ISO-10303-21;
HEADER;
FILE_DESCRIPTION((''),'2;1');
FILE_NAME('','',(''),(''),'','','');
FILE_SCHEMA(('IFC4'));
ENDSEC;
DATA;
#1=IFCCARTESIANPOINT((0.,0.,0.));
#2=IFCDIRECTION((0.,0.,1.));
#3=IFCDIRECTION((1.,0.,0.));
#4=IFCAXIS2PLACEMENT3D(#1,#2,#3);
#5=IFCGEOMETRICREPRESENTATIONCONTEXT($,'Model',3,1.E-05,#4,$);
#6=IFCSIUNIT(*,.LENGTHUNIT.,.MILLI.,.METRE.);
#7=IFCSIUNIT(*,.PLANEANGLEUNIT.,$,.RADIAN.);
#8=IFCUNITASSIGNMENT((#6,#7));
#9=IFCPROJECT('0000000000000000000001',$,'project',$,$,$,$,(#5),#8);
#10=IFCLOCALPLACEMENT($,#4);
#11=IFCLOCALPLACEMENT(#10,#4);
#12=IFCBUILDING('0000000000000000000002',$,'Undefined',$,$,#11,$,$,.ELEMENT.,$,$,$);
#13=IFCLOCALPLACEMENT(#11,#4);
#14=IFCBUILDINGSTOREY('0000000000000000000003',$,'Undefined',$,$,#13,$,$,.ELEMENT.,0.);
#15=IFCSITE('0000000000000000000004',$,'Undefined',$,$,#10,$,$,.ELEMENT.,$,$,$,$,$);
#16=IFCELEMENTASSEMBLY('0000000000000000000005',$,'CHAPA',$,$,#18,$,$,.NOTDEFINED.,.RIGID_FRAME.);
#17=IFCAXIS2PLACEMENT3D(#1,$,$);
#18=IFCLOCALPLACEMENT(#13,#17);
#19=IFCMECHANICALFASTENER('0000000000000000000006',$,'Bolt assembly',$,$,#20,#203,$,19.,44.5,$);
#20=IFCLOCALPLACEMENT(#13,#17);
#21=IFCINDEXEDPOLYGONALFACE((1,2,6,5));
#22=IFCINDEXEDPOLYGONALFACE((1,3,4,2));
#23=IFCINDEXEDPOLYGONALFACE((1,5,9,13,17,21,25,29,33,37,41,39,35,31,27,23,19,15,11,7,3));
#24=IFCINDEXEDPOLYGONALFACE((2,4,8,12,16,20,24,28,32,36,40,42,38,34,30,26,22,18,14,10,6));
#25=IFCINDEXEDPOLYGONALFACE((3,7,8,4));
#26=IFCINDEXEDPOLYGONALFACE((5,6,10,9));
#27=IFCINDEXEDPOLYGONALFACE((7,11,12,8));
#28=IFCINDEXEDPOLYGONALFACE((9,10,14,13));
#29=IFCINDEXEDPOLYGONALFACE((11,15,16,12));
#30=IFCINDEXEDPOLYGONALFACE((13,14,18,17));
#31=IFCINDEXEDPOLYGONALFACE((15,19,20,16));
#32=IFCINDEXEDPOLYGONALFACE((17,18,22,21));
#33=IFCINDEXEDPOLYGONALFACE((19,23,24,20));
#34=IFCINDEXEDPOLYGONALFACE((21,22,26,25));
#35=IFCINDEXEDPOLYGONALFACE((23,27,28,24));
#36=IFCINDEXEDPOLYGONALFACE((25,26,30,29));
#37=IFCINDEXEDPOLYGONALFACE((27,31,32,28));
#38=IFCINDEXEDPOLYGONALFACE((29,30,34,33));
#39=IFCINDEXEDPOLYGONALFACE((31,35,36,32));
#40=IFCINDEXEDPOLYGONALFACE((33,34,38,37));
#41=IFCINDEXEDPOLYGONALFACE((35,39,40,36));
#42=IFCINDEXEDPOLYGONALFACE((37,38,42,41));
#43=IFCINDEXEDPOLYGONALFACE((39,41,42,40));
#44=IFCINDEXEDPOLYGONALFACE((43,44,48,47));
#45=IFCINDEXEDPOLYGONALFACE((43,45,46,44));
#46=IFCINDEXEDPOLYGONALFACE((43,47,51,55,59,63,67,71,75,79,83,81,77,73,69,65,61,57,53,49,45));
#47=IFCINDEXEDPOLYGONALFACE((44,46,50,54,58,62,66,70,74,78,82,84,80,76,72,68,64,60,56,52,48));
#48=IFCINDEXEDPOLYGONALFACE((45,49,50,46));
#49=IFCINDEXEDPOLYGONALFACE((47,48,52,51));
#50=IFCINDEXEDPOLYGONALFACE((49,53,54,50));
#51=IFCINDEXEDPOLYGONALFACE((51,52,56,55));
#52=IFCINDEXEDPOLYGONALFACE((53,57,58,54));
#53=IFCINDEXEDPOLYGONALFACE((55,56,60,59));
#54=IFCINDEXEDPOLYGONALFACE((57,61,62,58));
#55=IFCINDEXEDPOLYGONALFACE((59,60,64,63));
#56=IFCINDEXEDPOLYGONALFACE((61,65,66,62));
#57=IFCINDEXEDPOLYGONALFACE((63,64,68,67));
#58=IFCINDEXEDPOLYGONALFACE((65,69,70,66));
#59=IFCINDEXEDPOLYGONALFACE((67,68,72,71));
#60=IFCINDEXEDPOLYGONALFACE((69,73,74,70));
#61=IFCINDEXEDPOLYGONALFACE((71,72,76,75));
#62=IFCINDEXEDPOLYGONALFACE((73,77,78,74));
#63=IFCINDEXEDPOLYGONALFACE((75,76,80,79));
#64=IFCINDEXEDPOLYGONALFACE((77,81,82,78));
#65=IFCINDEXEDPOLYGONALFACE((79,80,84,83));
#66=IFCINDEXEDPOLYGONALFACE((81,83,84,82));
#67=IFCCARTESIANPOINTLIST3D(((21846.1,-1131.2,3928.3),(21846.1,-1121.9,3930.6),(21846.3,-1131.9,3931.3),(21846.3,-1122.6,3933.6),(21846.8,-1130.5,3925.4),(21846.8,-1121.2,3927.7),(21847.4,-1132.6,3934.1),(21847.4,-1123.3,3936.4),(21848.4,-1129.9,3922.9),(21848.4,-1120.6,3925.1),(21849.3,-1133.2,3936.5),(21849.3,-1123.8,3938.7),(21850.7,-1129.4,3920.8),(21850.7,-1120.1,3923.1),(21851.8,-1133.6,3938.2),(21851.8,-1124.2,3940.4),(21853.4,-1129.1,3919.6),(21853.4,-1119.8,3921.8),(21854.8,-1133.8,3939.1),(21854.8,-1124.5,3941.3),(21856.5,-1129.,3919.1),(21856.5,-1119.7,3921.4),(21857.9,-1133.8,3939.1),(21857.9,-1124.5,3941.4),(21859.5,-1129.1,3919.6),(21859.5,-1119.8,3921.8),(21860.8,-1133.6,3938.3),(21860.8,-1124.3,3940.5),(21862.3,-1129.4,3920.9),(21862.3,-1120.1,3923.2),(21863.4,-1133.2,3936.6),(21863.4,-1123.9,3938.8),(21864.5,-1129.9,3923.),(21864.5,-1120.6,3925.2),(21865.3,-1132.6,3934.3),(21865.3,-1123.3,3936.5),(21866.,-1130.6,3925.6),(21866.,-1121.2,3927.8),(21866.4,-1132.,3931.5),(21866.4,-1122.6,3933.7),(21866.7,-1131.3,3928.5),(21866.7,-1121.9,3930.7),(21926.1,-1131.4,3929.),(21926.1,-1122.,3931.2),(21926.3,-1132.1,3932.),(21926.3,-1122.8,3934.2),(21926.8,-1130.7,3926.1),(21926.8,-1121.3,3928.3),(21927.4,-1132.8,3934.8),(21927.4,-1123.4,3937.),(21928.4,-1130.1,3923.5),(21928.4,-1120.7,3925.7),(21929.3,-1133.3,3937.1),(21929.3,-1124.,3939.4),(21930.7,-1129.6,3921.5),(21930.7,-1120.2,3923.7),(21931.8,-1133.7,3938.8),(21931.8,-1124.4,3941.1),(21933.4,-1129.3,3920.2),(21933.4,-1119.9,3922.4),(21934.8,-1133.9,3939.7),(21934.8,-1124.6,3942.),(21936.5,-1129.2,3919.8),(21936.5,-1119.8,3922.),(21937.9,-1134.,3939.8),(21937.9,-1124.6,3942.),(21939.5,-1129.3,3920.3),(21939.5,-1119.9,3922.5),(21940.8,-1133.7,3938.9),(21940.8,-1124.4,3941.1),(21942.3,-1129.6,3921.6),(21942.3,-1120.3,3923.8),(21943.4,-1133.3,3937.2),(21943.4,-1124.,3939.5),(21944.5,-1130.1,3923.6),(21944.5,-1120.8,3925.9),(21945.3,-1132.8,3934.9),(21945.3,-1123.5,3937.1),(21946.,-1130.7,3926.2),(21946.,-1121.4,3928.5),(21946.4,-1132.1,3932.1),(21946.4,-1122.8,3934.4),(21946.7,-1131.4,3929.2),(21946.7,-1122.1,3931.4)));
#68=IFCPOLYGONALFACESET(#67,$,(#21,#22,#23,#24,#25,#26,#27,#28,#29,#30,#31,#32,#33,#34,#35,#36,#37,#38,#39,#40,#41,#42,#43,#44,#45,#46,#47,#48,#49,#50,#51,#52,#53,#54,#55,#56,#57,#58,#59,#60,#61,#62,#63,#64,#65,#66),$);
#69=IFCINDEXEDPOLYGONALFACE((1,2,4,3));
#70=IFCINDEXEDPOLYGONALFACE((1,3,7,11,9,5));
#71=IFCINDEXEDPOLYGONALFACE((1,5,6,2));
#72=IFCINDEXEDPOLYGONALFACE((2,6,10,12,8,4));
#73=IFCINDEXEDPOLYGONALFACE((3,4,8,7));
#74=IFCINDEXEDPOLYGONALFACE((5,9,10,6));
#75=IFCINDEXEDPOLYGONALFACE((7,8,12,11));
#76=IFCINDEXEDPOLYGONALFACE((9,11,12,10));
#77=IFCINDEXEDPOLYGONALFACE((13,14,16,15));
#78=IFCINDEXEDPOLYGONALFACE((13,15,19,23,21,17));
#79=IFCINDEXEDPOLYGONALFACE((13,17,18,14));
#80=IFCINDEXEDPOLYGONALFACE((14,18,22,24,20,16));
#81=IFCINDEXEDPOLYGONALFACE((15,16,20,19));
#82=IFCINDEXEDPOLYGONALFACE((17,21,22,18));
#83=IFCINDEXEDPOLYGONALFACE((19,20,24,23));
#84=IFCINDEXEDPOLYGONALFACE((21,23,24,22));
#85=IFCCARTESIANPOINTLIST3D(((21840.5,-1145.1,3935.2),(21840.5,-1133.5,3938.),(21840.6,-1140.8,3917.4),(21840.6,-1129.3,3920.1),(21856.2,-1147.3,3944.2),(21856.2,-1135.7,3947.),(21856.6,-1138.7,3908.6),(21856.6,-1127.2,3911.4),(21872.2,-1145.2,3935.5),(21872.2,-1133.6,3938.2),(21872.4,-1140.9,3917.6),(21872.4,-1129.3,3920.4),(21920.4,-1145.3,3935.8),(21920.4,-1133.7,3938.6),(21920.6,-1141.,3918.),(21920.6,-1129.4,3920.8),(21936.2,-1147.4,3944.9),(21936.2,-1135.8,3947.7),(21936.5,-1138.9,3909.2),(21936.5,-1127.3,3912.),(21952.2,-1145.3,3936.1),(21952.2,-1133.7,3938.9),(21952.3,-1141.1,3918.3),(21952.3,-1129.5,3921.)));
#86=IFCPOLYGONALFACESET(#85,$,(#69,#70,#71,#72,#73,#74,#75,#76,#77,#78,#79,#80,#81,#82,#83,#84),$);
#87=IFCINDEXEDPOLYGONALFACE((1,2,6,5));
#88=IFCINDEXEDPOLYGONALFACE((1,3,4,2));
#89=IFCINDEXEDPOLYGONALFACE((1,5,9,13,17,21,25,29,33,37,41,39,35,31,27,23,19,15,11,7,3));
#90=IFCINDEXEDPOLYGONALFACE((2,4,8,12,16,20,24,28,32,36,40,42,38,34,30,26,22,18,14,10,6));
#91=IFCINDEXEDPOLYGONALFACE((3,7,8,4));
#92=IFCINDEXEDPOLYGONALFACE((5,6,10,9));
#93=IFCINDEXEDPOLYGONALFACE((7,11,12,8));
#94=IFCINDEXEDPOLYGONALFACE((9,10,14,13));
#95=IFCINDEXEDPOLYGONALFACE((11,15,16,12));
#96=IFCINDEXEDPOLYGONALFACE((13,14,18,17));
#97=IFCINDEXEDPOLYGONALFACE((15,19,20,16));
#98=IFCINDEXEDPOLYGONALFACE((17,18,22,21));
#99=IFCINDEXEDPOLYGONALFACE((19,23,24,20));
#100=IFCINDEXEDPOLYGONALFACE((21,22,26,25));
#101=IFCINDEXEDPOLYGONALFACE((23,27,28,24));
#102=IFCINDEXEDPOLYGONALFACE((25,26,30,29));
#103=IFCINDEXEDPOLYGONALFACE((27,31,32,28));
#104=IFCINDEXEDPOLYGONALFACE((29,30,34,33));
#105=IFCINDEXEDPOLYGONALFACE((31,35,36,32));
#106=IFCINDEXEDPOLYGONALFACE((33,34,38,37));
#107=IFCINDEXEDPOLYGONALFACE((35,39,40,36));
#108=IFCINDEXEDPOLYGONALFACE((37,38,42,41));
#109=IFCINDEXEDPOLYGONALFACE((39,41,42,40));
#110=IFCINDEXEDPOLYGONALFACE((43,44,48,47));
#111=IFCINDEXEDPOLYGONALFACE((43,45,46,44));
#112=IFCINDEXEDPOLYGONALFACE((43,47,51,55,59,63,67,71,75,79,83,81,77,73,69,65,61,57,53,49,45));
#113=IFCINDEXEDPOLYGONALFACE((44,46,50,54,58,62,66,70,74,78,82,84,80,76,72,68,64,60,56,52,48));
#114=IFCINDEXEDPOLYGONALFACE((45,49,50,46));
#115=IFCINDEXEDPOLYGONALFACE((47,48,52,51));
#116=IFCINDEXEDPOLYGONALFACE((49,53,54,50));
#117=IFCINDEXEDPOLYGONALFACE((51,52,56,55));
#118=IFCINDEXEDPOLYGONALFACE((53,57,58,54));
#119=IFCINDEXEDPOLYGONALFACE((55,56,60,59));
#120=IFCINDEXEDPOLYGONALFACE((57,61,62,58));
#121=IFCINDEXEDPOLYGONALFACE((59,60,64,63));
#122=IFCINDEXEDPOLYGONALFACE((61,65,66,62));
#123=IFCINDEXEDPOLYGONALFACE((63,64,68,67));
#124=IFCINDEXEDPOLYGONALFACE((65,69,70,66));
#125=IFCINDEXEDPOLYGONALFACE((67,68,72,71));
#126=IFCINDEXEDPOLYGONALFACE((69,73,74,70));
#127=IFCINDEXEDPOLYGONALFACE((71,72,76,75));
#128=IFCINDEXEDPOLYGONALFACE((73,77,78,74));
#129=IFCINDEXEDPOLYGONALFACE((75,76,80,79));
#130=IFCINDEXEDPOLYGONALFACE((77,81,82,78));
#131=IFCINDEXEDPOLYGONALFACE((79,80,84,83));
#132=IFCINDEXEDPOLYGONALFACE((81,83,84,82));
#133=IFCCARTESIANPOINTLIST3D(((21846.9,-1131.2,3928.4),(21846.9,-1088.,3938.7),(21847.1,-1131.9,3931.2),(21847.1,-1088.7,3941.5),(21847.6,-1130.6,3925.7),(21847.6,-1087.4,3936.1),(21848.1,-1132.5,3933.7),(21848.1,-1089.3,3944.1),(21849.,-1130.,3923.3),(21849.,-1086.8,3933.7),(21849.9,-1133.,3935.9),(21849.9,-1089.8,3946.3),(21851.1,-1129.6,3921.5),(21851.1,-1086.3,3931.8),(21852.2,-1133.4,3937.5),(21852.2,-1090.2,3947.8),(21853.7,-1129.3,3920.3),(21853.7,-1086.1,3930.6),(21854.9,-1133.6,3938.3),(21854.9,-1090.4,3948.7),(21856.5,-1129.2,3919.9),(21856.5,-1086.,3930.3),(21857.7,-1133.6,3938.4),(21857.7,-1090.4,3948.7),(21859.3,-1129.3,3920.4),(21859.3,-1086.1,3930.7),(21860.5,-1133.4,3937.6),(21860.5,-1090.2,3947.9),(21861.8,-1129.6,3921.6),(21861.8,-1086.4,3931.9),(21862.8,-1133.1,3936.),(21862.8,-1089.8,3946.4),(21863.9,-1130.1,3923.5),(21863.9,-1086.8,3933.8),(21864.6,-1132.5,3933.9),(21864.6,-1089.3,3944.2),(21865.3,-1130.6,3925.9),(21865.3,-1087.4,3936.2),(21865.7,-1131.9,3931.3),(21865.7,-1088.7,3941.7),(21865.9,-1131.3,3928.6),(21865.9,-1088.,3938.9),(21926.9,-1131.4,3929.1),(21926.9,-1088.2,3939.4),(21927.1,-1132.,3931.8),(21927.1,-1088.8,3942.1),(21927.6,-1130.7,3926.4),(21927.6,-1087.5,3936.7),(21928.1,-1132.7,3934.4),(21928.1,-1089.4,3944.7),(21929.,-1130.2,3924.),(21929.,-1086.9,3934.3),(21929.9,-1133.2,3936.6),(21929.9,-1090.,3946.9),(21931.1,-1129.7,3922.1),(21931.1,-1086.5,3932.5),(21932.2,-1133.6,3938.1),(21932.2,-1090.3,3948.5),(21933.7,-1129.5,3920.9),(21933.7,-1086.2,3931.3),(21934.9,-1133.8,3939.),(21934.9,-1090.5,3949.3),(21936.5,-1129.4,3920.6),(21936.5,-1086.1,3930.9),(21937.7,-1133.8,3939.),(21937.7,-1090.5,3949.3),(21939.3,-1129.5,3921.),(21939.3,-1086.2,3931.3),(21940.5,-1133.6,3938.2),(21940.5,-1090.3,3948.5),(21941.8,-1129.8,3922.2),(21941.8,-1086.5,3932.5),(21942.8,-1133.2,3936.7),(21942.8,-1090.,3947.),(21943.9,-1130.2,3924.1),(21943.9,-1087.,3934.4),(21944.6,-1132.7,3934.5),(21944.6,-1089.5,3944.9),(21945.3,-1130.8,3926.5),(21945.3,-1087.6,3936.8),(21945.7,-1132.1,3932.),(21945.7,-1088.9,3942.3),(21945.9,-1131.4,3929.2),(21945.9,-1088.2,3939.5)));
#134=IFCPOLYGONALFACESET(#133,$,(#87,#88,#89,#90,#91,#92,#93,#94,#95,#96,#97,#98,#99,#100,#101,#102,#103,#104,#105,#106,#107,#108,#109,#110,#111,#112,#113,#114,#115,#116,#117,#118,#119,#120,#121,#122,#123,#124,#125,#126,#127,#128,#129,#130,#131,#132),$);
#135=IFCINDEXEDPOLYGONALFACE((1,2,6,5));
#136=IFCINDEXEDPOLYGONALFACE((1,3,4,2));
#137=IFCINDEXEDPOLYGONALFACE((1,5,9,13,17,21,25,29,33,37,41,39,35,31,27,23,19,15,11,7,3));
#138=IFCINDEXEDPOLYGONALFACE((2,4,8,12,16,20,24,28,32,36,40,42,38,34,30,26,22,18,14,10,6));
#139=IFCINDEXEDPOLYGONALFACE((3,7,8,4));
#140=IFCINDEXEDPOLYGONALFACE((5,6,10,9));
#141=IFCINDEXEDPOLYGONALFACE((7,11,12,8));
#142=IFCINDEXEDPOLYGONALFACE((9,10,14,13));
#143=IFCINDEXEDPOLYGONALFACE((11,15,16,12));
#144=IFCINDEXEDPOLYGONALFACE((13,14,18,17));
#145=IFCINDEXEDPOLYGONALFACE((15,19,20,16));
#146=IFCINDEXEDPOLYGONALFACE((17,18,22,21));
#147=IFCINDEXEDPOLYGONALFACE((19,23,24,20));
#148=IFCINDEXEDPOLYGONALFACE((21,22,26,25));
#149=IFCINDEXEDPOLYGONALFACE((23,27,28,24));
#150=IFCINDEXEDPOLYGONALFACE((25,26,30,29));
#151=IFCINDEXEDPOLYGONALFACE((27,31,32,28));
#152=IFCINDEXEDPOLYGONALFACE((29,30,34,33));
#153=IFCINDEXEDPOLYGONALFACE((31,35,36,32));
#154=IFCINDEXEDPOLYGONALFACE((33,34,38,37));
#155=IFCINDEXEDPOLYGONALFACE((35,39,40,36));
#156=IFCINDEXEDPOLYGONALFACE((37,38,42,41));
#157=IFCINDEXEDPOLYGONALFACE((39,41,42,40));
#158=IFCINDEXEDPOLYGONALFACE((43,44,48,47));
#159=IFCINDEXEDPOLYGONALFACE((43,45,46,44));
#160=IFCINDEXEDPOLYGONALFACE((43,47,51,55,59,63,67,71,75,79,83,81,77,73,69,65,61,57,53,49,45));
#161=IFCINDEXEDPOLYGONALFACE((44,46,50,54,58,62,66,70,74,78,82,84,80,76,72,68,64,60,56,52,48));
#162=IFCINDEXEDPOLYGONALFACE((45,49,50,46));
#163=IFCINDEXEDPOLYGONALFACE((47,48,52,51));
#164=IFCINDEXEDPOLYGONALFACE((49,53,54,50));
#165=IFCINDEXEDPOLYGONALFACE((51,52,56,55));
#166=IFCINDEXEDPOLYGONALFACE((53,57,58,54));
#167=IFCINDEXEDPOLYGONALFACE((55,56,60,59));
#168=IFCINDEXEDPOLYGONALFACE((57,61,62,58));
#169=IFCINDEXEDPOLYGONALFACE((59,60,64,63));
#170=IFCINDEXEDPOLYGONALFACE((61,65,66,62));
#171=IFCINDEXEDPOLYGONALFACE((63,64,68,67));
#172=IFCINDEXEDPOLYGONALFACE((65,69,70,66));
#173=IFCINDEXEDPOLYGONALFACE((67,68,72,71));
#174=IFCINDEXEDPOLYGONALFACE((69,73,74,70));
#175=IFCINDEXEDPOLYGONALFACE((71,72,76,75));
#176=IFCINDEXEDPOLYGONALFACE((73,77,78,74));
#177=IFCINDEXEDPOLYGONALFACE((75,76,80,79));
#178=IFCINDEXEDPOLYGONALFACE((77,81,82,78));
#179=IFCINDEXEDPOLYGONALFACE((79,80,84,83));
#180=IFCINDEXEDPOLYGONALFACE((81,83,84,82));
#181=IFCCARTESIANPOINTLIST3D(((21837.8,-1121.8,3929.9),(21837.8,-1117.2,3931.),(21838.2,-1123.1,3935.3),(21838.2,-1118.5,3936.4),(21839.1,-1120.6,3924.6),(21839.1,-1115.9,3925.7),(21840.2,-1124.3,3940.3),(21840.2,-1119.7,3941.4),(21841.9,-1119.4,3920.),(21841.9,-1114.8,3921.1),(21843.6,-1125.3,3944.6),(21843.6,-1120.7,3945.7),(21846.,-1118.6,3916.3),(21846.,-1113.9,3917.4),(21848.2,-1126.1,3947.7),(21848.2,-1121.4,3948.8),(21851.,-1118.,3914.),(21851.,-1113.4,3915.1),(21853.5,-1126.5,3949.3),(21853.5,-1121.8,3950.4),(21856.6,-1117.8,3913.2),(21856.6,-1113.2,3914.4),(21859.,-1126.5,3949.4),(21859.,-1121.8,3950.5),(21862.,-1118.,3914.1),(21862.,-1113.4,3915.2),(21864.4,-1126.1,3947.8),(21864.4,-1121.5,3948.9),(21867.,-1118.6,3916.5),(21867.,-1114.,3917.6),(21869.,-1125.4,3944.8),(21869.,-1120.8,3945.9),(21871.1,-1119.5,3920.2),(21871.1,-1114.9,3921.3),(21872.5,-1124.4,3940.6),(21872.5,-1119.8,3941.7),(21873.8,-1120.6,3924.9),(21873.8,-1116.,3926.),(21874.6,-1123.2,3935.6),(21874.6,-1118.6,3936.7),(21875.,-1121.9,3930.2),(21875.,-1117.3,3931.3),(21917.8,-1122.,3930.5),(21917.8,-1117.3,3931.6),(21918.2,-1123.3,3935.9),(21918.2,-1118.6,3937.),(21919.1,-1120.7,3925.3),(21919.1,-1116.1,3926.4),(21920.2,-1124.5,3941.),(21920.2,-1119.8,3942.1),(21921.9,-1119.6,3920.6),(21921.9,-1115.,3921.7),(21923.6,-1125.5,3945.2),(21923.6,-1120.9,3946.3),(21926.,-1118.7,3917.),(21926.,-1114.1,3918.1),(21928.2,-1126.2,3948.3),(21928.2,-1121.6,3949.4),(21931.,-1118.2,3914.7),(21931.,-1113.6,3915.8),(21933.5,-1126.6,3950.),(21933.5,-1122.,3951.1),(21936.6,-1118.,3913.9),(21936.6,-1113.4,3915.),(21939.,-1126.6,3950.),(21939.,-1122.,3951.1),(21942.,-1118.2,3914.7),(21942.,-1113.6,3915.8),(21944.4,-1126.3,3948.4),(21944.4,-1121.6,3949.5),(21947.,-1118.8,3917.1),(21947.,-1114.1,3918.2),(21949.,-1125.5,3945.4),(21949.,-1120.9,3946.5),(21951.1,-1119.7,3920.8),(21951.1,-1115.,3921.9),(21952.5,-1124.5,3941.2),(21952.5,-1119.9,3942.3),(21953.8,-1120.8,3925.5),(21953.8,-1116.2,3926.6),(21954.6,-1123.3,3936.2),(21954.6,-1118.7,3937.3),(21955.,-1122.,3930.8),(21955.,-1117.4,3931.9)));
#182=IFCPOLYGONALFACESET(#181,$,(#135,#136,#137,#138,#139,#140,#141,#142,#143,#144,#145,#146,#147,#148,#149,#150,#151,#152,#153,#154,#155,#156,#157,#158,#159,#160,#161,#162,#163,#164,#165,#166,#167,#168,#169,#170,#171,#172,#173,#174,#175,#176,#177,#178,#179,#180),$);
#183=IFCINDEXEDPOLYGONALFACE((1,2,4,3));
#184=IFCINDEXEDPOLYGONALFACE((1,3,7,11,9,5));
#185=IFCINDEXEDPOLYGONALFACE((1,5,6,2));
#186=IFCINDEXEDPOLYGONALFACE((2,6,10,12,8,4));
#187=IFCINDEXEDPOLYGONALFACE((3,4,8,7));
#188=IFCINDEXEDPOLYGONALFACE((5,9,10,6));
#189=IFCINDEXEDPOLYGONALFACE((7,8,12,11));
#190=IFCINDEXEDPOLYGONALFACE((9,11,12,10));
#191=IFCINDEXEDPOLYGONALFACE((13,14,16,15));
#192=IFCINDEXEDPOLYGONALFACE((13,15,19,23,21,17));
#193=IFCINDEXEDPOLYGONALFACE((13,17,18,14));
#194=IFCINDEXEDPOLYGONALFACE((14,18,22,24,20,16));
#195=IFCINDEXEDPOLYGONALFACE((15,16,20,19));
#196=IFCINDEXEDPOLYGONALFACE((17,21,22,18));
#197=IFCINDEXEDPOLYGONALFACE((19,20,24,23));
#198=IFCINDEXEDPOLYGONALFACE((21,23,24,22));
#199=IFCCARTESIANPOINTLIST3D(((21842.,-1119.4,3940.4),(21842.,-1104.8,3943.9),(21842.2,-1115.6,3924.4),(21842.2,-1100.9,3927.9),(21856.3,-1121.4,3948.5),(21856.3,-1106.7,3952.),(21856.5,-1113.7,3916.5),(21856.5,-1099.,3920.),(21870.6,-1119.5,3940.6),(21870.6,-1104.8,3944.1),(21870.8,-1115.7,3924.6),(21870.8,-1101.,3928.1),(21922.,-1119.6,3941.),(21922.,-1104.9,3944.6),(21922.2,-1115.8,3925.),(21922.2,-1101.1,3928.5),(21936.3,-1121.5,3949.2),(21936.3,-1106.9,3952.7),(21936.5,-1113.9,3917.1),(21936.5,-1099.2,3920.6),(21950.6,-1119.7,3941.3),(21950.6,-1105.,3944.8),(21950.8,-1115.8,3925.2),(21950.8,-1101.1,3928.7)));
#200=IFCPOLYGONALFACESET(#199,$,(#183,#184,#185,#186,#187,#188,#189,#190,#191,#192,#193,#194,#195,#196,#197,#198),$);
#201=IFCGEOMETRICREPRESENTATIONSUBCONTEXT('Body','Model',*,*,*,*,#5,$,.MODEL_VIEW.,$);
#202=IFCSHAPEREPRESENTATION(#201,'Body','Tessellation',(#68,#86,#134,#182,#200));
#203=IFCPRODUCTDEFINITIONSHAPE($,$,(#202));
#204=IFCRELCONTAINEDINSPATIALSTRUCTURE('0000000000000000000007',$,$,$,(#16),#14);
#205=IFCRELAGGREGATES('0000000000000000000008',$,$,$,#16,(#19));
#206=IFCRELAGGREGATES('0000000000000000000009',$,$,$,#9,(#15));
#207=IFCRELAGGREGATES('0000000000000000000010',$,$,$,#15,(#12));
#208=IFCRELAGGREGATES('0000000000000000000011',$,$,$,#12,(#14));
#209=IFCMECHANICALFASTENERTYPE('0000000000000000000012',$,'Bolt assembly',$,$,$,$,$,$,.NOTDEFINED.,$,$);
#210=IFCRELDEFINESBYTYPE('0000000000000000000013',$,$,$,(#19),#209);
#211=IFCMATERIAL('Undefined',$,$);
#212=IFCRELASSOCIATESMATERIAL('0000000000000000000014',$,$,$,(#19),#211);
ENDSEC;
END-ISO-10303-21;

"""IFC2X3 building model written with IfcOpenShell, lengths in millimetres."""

from ifc_helpers import new_model, si_unit, frame, origin_with_axes, origin_2d_with_axis, place, context, subcontext, project, spatial, polyline, circle, outline, extrude, source, transform, mapped, material, type_object, element, aggregate, save


model = new_model("IFC2X3")

# Units and contexts
model_context = context("Model", 3, precision=1e-05, world=origin_with_axes())
body_context = subcontext(model_context, "Body", "Model", "MODEL_VIEW")
ifc_project = project(units=[si_unit("LENGTHUNIT", "METRE", prefix="MILLI"), si_unit("PLANEANGLEUNIT", "RADIAN")], contexts=[model_context])

# Site, building, storey
site_placement = place(None, origin_with_axes())
site = spatial("IfcSite", under=ifc_project, at=site_placement, Name="Undefined", CompositionType="ELEMENT")
building_placement = place(site_placement, origin_with_axes())
building = spatial("IfcBuilding", under=site, at=building_placement, Name="Undefined", CompositionType="ELEMENT")
storey_placement = place(building_placement, origin_with_axes())
storey = spatial("IfcBuildingStorey", under=building, at=storey_placement, Name="Undefined", CompositionType="ELEMENT", Elevation=0.0)

# Element assembly
assembly_1_placement = place(storey_placement, origin_with_axes())
assembly_1 = element("IfcElementAssembly", 1, at=assembly_1_placement, inside=storey, Name="CHAPA", AssemblyPlace="NOTDEFINED", PredefinedType="RIGID_FRAME")

# Shared definitions
ifc_material_1 = material(Name="Undefined")
mechanical_fastener_type = type_object("IfcMechanicalFastenerType", Name="Bolt assembly")

# Mechanical fastener
shared_shape_1 = source(origin_with_axes(), body_context, "Body", "SweptSolid", [
    extrude(circle(Radius=10.3, at=origin_2d_with_axis()), frame((0.0, 0.0, 0.0), z_axis=(0.0, 1.0, 0.0), x_axis=(1.0, 0.0, 0.0)), (0.0, 0.0, 1.0), 9.6),
    extrude(outline(polyline([(18.3, 0.0), (9.2, 15.9), (-9.2, 15.9), (-18.3, 0.0), (-9.2, -15.9), (9.2, -15.9), (18.3, 0.0)])), frame((0.0, -11.9, 0.0), z_axis=(0.0, 1.0, 0.0), x_axis=(1.0, 0.0, 0.0)), (0.0, 0.0, 1.0), 11.9),
    extrude(circle(Radius=9.5, at=origin_2d_with_axis()), frame((0.0, 0.0, 0.0), z_axis=(0.0, 1.0, 0.0), x_axis=(1.0, 0.0, 0.0)), (0.0, 0.0, 1.0), 44.5),
    extrude(circle(Radius=18.7, at=origin_2d_with_axis()), frame((0.0, 9.5, 0.0), z_axis=(0.0, 1.0, 0.0), x_axis=(1.0, 0.0, 0.0)), (0.0, 0.0, 1.0), 4.8),
    extrude(outline(polyline([(16.5, 0.0), (8.2, 14.3), (-8.2, 14.3), (-16.5, 0.0), (-8.2, -14.3), (8.2, -14.3), (16.5, 0.0)])), frame((0.0, 14.3, 0.0), z_axis=(0.0, 1.0, 0.0), x_axis=(1.0, 0.0, 0.0)), (0.0, 0.0, 1.0), 15.1),
])
mechanical_fastener_1_placement = place(assembly_1_placement, frame((21896.4, -1131.5, 3929.5), z_axis=(0.999966, -0.001918, 0.008027), x_axis=(0.008253, 0.23249, -0.972564)))
mechanical_fastener_1 = element("IfcMechanicalFastener", 2, at=mechanical_fastener_1_placement, type_object=mechanical_fastener_type, material=ifc_material_1, Name="Bolt assembly", NominalDiameter=19.0, NominalLength=44.5, context=body_context, shape_type="MappedRepresentation", body=[
    mapped(shared_shape_1, transform((0.0, 0.0, -40.0))),
    mapped(shared_shape_1, transform((0.0, 0.0, 40.0))),
])
aggregate(assembly_1, [mechanical_fastener_1])

save(model, "model.ifc")
